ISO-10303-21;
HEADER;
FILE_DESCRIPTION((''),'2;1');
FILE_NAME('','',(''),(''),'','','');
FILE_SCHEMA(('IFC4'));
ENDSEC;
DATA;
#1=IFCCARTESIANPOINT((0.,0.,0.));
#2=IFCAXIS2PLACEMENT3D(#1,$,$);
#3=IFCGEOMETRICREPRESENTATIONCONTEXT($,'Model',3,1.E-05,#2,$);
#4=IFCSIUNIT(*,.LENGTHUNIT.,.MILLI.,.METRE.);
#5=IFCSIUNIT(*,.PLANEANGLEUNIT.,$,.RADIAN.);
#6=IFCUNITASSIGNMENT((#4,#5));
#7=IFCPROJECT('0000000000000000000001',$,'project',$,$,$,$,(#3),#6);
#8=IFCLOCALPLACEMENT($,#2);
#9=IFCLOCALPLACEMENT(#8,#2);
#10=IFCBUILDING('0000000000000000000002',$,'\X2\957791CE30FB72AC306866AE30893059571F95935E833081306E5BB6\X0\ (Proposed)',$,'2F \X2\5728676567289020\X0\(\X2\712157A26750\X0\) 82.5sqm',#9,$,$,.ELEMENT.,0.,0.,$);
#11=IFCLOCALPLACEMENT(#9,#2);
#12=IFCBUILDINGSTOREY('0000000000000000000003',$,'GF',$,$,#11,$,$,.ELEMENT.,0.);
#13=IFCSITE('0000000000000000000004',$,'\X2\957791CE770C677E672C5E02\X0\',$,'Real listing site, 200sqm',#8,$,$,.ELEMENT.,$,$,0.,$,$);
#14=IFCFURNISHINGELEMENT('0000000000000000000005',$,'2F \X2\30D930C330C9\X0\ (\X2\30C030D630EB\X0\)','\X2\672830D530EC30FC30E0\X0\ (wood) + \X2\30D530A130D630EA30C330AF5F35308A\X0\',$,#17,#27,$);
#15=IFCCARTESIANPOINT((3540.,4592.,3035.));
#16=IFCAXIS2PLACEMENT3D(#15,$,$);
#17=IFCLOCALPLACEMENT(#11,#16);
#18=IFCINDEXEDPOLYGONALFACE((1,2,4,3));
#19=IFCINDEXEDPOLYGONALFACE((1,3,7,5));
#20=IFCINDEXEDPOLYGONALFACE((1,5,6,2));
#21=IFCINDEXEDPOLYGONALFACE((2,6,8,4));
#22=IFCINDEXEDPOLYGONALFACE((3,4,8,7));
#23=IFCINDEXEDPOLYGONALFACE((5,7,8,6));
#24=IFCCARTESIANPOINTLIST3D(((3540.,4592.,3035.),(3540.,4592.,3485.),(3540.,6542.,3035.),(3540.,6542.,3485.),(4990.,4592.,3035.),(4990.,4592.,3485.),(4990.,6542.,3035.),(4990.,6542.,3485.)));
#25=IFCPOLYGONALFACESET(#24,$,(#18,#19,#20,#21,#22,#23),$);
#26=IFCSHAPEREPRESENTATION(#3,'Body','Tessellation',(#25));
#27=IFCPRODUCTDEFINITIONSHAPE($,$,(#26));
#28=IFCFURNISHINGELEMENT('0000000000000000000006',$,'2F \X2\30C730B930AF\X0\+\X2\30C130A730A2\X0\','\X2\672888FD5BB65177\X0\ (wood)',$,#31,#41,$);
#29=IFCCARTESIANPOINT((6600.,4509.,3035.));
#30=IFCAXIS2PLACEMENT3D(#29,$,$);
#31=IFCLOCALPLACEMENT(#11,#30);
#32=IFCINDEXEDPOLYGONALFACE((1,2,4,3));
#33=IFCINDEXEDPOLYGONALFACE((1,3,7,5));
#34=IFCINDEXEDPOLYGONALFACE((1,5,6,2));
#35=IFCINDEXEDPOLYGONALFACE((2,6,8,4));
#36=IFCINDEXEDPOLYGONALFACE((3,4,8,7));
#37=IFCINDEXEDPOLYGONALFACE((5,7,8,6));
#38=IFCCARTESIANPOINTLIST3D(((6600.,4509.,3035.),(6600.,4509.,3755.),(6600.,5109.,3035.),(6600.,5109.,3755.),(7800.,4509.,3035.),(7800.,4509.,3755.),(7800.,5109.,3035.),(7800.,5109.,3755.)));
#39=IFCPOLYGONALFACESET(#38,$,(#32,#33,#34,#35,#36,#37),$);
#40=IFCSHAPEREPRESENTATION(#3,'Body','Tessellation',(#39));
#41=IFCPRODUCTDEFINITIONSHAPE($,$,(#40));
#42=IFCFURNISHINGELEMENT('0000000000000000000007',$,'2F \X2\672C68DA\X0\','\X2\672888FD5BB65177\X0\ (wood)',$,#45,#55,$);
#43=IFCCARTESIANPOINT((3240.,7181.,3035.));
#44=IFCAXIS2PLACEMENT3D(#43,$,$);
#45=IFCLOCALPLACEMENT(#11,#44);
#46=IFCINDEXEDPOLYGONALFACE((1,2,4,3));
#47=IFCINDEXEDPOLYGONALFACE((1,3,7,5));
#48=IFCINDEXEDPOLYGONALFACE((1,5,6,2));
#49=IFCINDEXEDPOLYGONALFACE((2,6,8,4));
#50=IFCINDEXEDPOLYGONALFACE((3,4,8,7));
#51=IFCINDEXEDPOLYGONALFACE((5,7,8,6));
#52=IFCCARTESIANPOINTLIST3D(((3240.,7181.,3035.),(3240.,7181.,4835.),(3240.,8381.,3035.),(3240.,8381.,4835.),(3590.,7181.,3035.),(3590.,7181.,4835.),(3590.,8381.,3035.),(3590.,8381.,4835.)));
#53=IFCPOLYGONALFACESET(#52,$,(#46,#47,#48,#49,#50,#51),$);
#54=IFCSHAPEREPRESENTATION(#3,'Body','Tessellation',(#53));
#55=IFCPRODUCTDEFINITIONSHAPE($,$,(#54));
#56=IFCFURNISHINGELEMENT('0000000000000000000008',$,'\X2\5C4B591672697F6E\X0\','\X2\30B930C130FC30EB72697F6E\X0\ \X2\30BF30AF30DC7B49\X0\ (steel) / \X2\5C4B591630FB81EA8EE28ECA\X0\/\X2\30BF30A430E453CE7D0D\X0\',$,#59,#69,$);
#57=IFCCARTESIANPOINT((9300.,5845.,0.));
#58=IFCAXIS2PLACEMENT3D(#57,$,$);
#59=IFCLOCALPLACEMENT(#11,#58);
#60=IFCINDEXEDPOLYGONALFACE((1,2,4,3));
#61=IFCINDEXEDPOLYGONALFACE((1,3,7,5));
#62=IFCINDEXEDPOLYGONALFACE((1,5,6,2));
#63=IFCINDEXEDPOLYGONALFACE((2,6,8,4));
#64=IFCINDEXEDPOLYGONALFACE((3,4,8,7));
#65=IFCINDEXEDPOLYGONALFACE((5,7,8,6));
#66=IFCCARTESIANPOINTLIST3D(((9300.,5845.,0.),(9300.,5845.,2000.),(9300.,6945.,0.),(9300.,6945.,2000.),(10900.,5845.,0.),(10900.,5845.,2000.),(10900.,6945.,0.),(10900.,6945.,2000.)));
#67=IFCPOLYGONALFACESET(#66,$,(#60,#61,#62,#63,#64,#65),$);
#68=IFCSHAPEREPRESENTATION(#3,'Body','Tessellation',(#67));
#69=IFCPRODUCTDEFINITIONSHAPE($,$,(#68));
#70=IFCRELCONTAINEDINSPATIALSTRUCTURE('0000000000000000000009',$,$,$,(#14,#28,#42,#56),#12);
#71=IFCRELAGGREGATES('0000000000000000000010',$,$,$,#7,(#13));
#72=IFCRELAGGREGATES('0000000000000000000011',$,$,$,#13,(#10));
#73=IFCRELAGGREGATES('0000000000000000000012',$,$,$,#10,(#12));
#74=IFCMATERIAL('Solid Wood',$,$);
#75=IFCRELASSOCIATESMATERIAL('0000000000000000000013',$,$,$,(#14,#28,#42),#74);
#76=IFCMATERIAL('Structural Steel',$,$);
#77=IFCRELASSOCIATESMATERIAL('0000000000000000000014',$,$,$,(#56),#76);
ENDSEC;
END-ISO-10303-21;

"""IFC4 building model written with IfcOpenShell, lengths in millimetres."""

from ifc_helpers import new_model, si_unit, frame, frame_2d, origin, place, context, project, spatial, rectangle, extrude, material, element, save


model = new_model("IFC4")

# Units and contexts
model_context = context("Model", 3, precision=1e-05, world=origin())
ifc_project = project(units=[si_unit("LENGTHUNIT", "METRE", prefix="MILLI"), si_unit("PLANEANGLEUNIT", "RADIAN")], contexts=[model_context])

# Site, building, storey
site_placement = place(None, origin())
site = spatial("IfcSite", under=ifc_project, at=site_placement, Name="長野県松本市", ObjectType="Real listing site, 200sqm", CompositionType="ELEMENT", RefElevation=0.0)
building_placement = place(site_placement, origin())
building = spatial("IfcBuilding", under=site, at=building_placement, Name="長野・犬と暮らす土間広めの家 (Proposed)", ObjectType="2F 在来木造(無垢材) 82.5sqm", CompositionType="ELEMENT", ElevationOfRefHeight=0.0, ElevationOfTerrain=0.0)
storey_placement = place(building_placement, origin())
storey = spatial("IfcBuildingStorey", under=building, at=storey_placement, Name="GF", CompositionType="ELEMENT", Elevation=0.0)

# Shared definitions
ifc_material_1 = material(Name="Solid Wood")

# Shared definitions
ifc_material_2 = material(Name="Structural Steel")

# Furnishing elements
furnishing_1_placement = place(storey_placement, frame((3540.0, 4592.0, 3035.0)))
element("IfcFurnishingElement", 1, at=furnishing_1_placement, inside=storey, material=ifc_material_1, Name="2F ベッド (ダブル)", Description="木フレーム (wood) + ファブリック張り", context=model_context, shape_type="SweptSolid", body=[
    extrude(rectangle(XDim=1450.0, YDim=1950.0, at=frame_2d((725.0, 975.0))), frame((3540.0, 4592.0, 3035.0)), (0.0, 0.0, 1.0), 450.0),
])
furnishing_2_placement = place(storey_placement, frame((6600.0, 4509.0, 3035.0)))
element("IfcFurnishingElement", 2, at=furnishing_2_placement, inside=storey, material=ifc_material_1, Name="2F デスク+チェア", Description="木製家具 (wood)", context=model_context, shape_type="SweptSolid", body=[
    extrude(rectangle(XDim=1200.0, YDim=600.0, at=frame_2d((600.0, 300.0))), frame((6600.0, 4509.0, 3035.0)), (0.0, 0.0, 1.0), 720.0),
])
furnishing_3_placement = place(storey_placement, frame((3240.0, 7181.0, 3035.0)))
element("IfcFurnishingElement", 3, at=furnishing_3_placement, inside=storey, material=ifc_material_1, Name="2F 本棚", Description="木製家具 (wood)", context=model_context, shape_type="SweptSolid", body=[
    extrude(rectangle(XDim=350.0, YDim=1200.0, at=frame_2d((175.0, 600.0))), frame((3240.0, 7181.0, 3035.0)), (0.0, 0.0, 1.0), 1800.0),
])
furnishing_4_placement = place(storey_placement, frame((9300.0, 5845.0, 0.0)))
element("IfcFurnishingElement", 4, at=furnishing_4_placement, inside=storey, material=ifc_material_2, Name="屋外物置", Description="スチール物置 タクボ等 (steel) / 屋外・自転車/タイヤ収納", context=model_context, shape_type="SweptSolid", body=[
    extrude(rectangle(XDim=1600.0, YDim=1100.0, at=frame_2d((800.0, 550.0))), frame((9300.0, 5845.0, 0.0)), (0.0, 0.0, 1.0), 2000.0),
])

save(model, "model.ifc")
